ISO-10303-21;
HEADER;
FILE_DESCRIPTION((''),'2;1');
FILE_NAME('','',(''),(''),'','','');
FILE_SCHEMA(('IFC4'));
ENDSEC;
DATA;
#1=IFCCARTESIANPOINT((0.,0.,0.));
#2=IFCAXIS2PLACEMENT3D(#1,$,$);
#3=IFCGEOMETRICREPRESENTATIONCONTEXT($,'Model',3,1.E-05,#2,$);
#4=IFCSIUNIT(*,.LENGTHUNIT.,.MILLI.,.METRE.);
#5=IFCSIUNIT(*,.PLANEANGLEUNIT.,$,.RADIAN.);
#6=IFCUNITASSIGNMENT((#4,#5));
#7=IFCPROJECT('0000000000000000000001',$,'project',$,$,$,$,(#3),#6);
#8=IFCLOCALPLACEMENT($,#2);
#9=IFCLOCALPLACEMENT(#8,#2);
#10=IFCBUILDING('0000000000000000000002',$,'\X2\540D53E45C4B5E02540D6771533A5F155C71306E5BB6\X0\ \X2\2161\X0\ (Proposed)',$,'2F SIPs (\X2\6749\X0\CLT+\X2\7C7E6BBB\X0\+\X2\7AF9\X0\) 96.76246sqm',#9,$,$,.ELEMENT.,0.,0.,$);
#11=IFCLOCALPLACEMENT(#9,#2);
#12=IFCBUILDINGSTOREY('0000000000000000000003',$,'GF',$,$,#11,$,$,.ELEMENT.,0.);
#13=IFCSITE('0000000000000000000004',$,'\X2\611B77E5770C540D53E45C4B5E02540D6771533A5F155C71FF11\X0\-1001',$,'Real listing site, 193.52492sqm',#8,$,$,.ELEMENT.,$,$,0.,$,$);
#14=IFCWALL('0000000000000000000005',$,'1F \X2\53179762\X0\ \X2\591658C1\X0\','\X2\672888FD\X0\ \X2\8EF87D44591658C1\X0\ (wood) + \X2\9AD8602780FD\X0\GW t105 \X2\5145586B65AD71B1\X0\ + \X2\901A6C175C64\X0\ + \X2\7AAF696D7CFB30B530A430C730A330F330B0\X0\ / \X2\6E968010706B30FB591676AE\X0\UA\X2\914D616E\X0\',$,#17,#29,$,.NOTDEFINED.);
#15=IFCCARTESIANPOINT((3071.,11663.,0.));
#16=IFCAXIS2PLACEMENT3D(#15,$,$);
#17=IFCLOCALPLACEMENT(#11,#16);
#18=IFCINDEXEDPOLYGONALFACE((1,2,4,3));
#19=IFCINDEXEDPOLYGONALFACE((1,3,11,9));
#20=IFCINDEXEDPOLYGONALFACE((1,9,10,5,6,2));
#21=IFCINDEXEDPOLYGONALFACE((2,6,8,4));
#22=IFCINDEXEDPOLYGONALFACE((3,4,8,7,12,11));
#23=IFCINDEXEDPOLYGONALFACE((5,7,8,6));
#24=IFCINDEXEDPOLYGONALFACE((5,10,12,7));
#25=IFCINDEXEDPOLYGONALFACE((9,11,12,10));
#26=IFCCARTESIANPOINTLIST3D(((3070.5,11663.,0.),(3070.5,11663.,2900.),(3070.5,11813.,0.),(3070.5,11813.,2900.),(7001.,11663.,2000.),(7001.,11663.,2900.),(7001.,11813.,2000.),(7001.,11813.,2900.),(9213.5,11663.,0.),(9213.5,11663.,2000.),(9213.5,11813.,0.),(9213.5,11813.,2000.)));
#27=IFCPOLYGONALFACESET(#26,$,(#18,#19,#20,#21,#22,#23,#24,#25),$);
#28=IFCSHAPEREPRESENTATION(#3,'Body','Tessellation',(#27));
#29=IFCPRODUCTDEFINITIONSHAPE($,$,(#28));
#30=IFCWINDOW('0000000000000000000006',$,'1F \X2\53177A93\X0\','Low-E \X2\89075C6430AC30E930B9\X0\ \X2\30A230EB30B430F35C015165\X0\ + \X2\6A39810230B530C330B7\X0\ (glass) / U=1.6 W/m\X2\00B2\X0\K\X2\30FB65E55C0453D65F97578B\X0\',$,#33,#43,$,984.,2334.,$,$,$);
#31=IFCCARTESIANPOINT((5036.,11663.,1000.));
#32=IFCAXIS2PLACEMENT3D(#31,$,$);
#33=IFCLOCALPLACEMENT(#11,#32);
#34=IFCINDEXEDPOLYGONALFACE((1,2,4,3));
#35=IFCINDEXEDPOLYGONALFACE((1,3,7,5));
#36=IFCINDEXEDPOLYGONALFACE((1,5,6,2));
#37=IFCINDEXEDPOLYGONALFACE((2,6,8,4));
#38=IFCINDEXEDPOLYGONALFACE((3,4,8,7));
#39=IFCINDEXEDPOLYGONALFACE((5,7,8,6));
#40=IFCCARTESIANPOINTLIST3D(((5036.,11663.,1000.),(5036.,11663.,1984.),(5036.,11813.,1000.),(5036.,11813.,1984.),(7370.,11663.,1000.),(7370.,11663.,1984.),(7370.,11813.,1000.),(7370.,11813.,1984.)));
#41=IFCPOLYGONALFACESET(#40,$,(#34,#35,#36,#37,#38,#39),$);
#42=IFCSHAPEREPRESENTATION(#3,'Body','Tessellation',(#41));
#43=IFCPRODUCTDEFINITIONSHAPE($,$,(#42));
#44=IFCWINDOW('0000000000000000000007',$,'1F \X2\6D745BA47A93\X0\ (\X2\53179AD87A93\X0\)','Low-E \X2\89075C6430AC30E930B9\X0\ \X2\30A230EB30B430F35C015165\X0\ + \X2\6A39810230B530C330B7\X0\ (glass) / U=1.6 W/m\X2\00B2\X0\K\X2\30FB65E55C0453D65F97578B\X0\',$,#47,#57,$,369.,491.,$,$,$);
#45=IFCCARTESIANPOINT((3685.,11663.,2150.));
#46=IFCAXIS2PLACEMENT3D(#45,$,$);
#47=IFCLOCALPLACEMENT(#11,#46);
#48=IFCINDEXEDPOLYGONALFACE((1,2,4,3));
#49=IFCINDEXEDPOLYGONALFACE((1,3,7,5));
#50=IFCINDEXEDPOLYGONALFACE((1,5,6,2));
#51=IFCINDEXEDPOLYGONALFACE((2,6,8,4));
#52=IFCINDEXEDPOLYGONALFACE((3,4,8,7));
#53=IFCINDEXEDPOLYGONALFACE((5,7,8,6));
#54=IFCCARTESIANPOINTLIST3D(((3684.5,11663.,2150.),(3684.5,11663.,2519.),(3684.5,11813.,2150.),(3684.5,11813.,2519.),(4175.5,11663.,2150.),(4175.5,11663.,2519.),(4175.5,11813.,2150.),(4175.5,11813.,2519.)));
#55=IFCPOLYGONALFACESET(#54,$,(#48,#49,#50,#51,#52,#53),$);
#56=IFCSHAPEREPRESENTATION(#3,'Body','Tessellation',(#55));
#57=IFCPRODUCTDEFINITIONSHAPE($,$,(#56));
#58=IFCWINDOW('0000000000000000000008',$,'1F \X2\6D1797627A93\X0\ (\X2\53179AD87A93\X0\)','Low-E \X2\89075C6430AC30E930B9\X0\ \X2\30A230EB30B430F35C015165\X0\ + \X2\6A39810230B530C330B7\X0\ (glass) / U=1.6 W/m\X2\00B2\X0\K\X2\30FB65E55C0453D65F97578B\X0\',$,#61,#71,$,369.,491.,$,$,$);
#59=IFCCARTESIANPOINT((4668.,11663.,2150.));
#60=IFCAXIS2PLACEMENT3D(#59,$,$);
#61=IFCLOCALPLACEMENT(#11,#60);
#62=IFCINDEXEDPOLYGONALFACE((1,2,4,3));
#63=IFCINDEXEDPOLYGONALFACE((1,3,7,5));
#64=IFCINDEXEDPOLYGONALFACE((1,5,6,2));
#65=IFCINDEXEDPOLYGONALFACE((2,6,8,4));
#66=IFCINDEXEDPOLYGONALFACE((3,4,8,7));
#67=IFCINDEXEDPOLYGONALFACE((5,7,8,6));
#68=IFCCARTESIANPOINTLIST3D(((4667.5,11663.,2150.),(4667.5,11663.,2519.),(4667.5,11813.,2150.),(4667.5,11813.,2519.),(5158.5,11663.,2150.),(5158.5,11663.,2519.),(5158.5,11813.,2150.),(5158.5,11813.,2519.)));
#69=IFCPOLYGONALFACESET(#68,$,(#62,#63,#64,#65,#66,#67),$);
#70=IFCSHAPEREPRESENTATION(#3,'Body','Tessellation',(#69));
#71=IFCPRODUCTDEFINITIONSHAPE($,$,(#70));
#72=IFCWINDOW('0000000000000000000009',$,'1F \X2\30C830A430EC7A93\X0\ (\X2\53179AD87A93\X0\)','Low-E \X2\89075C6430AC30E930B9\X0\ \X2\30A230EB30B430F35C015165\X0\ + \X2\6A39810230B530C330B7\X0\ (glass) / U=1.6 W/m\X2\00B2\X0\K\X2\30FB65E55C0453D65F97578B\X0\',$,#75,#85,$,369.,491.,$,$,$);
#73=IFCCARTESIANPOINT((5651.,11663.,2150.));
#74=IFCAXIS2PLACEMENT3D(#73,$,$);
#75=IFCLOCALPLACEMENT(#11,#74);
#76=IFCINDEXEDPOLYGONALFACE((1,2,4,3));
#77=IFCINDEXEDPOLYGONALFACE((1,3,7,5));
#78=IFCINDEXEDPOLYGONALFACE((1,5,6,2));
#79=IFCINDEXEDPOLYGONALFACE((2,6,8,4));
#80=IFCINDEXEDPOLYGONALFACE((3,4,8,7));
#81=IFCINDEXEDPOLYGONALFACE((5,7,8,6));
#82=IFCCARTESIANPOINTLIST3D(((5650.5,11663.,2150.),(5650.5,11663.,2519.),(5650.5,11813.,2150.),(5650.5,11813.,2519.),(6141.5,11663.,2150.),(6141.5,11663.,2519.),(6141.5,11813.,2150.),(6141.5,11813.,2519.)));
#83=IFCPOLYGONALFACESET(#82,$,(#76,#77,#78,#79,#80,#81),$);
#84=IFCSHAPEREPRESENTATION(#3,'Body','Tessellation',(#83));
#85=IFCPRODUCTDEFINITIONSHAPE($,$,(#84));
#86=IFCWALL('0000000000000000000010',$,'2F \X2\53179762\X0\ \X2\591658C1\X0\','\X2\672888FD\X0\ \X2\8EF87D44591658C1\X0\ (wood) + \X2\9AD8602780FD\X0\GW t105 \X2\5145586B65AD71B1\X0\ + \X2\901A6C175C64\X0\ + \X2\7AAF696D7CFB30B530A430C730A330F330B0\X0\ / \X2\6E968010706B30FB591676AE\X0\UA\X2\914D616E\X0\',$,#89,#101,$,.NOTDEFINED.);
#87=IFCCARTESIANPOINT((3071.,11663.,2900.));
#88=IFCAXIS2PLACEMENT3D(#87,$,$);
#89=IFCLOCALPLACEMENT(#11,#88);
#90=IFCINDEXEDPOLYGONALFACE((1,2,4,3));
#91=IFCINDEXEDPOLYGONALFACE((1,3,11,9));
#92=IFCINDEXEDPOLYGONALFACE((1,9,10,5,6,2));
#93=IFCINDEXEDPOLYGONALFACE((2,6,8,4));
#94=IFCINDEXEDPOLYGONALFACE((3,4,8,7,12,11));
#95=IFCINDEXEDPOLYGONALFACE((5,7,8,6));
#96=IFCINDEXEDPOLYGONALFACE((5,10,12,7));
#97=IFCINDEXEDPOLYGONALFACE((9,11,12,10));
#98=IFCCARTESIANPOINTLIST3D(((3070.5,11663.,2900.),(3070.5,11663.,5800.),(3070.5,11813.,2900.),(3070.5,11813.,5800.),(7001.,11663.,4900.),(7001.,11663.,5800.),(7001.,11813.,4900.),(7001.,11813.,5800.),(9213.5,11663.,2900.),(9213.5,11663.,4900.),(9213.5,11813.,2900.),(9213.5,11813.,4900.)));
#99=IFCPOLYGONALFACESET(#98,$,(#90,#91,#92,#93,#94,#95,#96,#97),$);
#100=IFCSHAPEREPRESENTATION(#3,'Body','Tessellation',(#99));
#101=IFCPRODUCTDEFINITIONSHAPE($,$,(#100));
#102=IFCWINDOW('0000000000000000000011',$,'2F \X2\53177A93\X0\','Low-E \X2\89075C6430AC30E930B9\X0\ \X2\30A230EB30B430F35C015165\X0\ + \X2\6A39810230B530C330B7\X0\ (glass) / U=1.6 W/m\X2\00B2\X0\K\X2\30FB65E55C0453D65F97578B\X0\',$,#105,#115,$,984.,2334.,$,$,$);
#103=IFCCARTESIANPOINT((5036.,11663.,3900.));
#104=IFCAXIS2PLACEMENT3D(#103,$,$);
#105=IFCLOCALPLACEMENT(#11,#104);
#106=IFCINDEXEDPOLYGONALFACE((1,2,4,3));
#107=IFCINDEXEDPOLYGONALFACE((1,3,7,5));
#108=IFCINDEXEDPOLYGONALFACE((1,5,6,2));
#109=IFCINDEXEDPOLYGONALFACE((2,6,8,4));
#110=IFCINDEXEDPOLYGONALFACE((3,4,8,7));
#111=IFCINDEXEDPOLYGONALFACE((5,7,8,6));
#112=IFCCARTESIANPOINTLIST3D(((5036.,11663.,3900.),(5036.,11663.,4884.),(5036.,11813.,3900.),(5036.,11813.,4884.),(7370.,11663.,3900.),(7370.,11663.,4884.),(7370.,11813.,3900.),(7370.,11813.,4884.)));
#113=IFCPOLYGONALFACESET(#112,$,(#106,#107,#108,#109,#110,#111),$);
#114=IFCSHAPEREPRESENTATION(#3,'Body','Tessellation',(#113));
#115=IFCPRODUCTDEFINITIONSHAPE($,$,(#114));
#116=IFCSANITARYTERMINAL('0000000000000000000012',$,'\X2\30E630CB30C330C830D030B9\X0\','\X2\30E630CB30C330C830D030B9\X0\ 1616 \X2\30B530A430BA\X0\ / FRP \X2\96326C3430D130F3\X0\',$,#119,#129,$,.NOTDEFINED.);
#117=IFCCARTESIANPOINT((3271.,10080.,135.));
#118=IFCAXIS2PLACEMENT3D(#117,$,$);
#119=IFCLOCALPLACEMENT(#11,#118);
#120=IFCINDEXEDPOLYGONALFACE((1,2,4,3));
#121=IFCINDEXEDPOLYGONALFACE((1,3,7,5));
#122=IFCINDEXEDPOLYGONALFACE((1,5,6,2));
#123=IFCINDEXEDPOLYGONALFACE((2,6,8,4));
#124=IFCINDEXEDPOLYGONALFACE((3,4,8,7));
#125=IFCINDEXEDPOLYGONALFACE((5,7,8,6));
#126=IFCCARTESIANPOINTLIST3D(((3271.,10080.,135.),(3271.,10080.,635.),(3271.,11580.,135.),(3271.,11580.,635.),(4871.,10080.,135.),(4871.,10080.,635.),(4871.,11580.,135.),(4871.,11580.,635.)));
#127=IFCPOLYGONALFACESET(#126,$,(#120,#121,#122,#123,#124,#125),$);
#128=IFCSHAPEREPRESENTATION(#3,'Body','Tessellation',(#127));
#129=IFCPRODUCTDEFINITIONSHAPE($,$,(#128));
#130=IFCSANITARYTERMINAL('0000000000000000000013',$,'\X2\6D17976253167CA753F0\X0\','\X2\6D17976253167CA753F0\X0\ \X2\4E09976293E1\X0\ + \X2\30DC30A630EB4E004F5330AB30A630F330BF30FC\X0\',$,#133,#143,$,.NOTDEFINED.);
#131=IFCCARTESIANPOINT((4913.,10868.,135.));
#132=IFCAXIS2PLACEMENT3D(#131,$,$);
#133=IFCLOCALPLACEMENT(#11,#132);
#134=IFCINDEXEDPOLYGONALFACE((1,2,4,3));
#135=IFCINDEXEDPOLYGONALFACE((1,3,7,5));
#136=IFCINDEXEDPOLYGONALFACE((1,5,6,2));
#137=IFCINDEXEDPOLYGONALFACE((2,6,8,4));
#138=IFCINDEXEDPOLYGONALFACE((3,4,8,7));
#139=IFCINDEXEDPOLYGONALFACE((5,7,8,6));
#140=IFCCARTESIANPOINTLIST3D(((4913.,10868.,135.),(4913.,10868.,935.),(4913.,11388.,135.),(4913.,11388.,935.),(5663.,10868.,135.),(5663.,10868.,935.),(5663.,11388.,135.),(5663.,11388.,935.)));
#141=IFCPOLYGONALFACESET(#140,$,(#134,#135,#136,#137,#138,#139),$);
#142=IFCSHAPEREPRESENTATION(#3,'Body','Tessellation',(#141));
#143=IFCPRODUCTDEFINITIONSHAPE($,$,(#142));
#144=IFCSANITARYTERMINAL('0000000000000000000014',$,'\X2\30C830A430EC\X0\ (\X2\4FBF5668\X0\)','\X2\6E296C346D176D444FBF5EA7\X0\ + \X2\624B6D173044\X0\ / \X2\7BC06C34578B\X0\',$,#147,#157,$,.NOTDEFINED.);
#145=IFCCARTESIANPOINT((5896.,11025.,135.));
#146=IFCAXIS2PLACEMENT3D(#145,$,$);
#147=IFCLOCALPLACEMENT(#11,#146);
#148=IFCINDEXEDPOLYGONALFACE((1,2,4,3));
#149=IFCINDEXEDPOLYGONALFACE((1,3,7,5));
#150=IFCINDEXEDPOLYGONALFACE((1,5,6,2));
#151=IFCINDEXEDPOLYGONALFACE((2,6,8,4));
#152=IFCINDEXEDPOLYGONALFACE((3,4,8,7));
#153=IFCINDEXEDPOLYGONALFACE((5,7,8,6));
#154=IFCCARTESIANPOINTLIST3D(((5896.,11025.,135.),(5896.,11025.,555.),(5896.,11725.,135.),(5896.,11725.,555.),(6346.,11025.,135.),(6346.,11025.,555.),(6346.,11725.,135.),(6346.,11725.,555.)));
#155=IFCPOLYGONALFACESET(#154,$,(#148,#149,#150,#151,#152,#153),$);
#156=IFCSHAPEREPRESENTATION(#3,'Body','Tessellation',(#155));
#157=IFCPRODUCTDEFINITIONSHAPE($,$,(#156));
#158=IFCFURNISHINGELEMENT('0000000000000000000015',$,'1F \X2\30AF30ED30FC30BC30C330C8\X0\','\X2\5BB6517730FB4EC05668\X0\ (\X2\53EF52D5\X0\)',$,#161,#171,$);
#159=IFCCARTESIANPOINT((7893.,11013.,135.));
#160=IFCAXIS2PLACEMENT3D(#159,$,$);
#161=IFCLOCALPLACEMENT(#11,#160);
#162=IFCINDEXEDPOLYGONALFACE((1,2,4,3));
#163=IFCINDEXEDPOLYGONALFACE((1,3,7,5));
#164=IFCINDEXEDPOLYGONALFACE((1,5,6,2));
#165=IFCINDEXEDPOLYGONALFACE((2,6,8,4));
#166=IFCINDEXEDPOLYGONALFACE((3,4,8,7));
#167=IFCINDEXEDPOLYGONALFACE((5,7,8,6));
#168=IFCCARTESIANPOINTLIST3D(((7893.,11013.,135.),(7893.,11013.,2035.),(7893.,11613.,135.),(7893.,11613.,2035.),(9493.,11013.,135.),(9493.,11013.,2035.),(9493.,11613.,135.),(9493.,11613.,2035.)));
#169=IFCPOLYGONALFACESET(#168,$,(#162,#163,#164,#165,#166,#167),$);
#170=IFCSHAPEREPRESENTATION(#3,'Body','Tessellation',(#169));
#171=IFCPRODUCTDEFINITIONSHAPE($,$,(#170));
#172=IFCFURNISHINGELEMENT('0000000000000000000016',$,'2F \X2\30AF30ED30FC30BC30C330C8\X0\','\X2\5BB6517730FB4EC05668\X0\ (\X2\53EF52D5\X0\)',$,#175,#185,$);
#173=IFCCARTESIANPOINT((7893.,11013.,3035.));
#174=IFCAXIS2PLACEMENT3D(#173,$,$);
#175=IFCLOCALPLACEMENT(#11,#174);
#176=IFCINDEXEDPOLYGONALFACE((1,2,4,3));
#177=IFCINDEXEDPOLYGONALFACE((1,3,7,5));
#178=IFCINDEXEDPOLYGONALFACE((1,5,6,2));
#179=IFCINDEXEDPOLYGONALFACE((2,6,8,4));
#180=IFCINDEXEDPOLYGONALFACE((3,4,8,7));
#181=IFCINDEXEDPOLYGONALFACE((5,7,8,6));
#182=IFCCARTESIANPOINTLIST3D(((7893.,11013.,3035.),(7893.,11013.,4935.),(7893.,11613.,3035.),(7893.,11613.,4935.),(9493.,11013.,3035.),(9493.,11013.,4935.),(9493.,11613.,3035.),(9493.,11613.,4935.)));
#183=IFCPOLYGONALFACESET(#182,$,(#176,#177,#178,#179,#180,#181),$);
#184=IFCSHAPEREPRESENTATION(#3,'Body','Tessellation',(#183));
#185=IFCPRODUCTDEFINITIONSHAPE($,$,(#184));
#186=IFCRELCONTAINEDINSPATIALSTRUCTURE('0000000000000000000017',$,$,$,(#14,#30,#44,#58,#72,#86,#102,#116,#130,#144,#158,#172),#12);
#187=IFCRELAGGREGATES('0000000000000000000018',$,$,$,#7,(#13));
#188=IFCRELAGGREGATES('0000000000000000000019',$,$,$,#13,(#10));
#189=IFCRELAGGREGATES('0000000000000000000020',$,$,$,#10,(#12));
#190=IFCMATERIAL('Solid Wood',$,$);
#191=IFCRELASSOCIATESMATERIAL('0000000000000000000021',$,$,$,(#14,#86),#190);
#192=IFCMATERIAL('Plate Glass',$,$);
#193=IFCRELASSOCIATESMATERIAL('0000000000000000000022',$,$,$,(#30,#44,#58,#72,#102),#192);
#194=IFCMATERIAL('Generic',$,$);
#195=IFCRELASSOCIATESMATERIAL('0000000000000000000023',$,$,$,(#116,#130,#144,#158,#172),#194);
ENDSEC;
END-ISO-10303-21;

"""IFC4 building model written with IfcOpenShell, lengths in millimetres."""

from ifc_helpers import new_model, si_unit, frame, frame_2d, origin, place, context, project, spatial, rectangle, extrude, material, element, fill, save


model = new_model("IFC4")

# Units and contexts
model_context = context("Model", 3, precision=1e-05, world=origin())
ifc_project = project(units=[si_unit("LENGTHUNIT", "METRE", prefix="MILLI"), si_unit("PLANEANGLEUNIT", "RADIAN")], contexts=[model_context])

# Site, building, storey
site_placement = place(None, origin())
site = spatial("IfcSite", under=ifc_project, at=site_placement, Name="愛知県名古屋市名東区引山１-1001", ObjectType="Real listing site, 193.52492sqm", CompositionType="ELEMENT", RefElevation=0.0)
building_placement = place(site_placement, origin())
building = spatial("IfcBuilding", under=site, at=building_placement, Name="名古屋市名東区引山の家 Ⅱ (Proposed)", ObjectType="2F SIPs (杉CLT+籾殻+竹) 96.76246sqm", CompositionType="ELEMENT", ElevationOfRefHeight=0.0, ElevationOfTerrain=0.0)
storey_placement = place(building_placement, origin())
storey = spatial("IfcBuildingStorey", under=building, at=storey_placement, Name="GF", CompositionType="ELEMENT", Elevation=0.0)

# Wall, openings, windows
ifc_material_1 = material(Name="Solid Wood")
wall_1_placement = place(storey_placement, frame((3071.0, 11663.0, 0.0)))
wall_1 = element("IfcWall", 1, at=wall_1_placement, inside=storey, material=ifc_material_1, Name="1F 北面 外壁", Description="木製 軸組外壁 (wood) + 高性能GW t105 充填断熱 + 通気層 + 窯業系サイディング / 準耐火・外皮UA配慮", PredefinedType="NOTDEFINED", context=model_context, shape_type="SweptSolid", body=[
    extrude(rectangle(XDim=6143.0, YDim=150.0, at=frame_2d((3071.0, 75.0))), frame((3071.0, 11663.0, 0.0)), (0.0, 0.0, 1.0), 2900.0),
])
opening_1_placement = place(storey_placement, frame((5036.0, 11663.0, 1000.0)))
opening_1 = element("IfcOpeningElement", 2, at=opening_1_placement, cuts=wall_1, PredefinedType="NOTDEFINED", context=model_context, shape_type="SweptSolid", body=[
    extrude(rectangle(XDim=2334.0, YDim=150.0, at=frame_2d((1167.0, 75.0))), frame((5036.0, 11663.0, 1000.0)), (0.0, 0.0, 1.0), 984.0),
])
opening_2_placement = place(storey_placement, frame((3685.0, 11663.0, 2150.0)))
opening_2 = element("IfcOpeningElement", 3, at=opening_2_placement, cuts=wall_1, PredefinedType="NOTDEFINED", context=model_context, shape_type="SweptSolid", body=[
    extrude(rectangle(XDim=491.0, YDim=150.0, at=frame_2d((245.0, 75.0))), frame((3685.0, 11663.0, 2150.0)), (0.0, 0.0, 1.0), 369.0),
])
opening_3_placement = place(storey_placement, frame((4668.0, 11663.0, 2150.0)))
opening_3 = element("IfcOpeningElement", 4, at=opening_3_placement, cuts=wall_1, PredefinedType="NOTDEFINED", context=model_context, shape_type="SweptSolid", body=[
    extrude(rectangle(XDim=491.0, YDim=150.0, at=frame_2d((245.0, 75.0))), frame((4668.0, 11663.0, 2150.0)), (0.0, 0.0, 1.0), 369.0),
])
opening_4_placement = place(storey_placement, frame((5651.0, 11663.0, 2150.0)))
opening_4 = element("IfcOpeningElement", 5, at=opening_4_placement, cuts=wall_1, PredefinedType="NOTDEFINED", context=model_context, shape_type="SweptSolid", body=[
    extrude(rectangle(XDim=491.0, YDim=150.0, at=frame_2d((245.0, 75.0))), frame((5651.0, 11663.0, 2150.0)), (0.0, 0.0, 1.0), 369.0),
])
ifc_material_2 = material(Name="Plate Glass")
window_1_placement = place(storey_placement, frame((5036.0, 11663.0, 1000.0)))
window_1 = element("IfcWindow", 6, at=window_1_placement, inside=storey, material=ifc_material_2, Name="1F 北窓", Description="Low-E 複層ガラス アルゴン封入 + 樹脂サッシ (glass) / U=1.6 W/m²K・日射取得型", OverallHeight=984.0, OverallWidth=2334.0, context=model_context, shape_type="SweptSolid", body=[
    extrude(rectangle(XDim=2334.0, YDim=150.0, at=frame_2d((1167.0, 75.0))), frame((5036.0, 11663.0, 1000.0)), (0.0, 0.0, 1.0), 984.0),
])
fill(opening_1, window_1)
window_2_placement = place(storey_placement, frame((3685.0, 11663.0, 2150.0)))
window_2 = element("IfcWindow", 7, at=window_2_placement, inside=storey, material=ifc_material_2, Name="1F 浴室窓 (北高窓)", Description="Low-E 複層ガラス アルゴン封入 + 樹脂サッシ (glass) / U=1.6 W/m²K・日射取得型", OverallHeight=369.0, OverallWidth=491.0, context=model_context, shape_type="SweptSolid", body=[
    extrude(rectangle(XDim=491.0, YDim=150.0, at=frame_2d((245.0, 75.0))), frame((3685.0, 11663.0, 2150.0)), (0.0, 0.0, 1.0), 369.0),
])
fill(opening_2, window_2)
window_3_placement = place(storey_placement, frame((4668.0, 11663.0, 2150.0)))
window_3 = element("IfcWindow", 8, at=window_3_placement, inside=storey, material=ifc_material_2, Name="1F 洗面窓 (北高窓)", Description="Low-E 複層ガラス アルゴン封入 + 樹脂サッシ (glass) / U=1.6 W/m²K・日射取得型", OverallHeight=369.0, OverallWidth=491.0, context=model_context, shape_type="SweptSolid", body=[
    extrude(rectangle(XDim=491.0, YDim=150.0, at=frame_2d((245.0, 75.0))), frame((4668.0, 11663.0, 2150.0)), (0.0, 0.0, 1.0), 369.0),
])
fill(opening_3, window_3)
window_4_placement = place(storey_placement, frame((5651.0, 11663.0, 2150.0)))
window_4 = element("IfcWindow", 9, at=window_4_placement, inside=storey, material=ifc_material_2, Name="1F トイレ窓 (北高窓)", Description="Low-E 複層ガラス アルゴン封入 + 樹脂サッシ (glass) / U=1.6 W/m²K・日射取得型", OverallHeight=369.0, OverallWidth=491.0, context=model_context, shape_type="SweptSolid", body=[
    extrude(rectangle(XDim=491.0, YDim=150.0, at=frame_2d((245.0, 75.0))), frame((5651.0, 11663.0, 2150.0)), (0.0, 0.0, 1.0), 369.0),
])
fill(opening_4, window_4)

# Wall, opening, window
wall_2_placement = place(storey_placement, frame((3071.0, 11663.0, 2900.0)))
wall_2 = element("IfcWall", 10, at=wall_2_placement, inside=storey, material=ifc_material_1, Name="2F 北面 外壁", Description="木製 軸組外壁 (wood) + 高性能GW t105 充填断熱 + 通気層 + 窯業系サイディング / 準耐火・外皮UA配慮", PredefinedType="NOTDEFINED", context=model_context, shape_type="SweptSolid", body=[
    extrude(rectangle(XDim=6143.0, YDim=150.0, at=frame_2d((3071.0, 75.0))), frame((3071.0, 11663.0, 2900.0)), (0.0, 0.0, 1.0), 2900.0),
])
opening_5_placement = place(storey_placement, frame((5036.0, 11663.0, 3900.0)))
opening_5 = element("IfcOpeningElement", 11, at=opening_5_placement, cuts=wall_2, PredefinedType="NOTDEFINED", context=model_context, shape_type="SweptSolid", body=[
    extrude(rectangle(XDim=2334.0, YDim=150.0, at=frame_2d((1167.0, 75.0))), frame((5036.0, 11663.0, 3900.0)), (0.0, 0.0, 1.0), 984.0),
])
window_5_placement = place(storey_placement, frame((5036.0, 11663.0, 3900.0)))
window_5 = element("IfcWindow", 12, at=window_5_placement, inside=storey, material=ifc_material_2, Name="2F 北窓", Description="Low-E 複層ガラス アルゴン封入 + 樹脂サッシ (glass) / U=1.6 W/m²K・日射取得型", OverallHeight=984.0, OverallWidth=2334.0, context=model_context, shape_type="SweptSolid", body=[
    extrude(rectangle(XDim=2334.0, YDim=150.0, at=frame_2d((1167.0, 75.0))), frame((5036.0, 11663.0, 3900.0)), (0.0, 0.0, 1.0), 984.0),
])
fill(opening_5, window_5)

# Sanitary terminals
ifc_material_3 = material(Name="Generic")
sanitary_terminal_1_placement = place(storey_placement, frame((3271.0, 10080.0, 135.0)))
element("IfcSanitaryTerminal", 13, at=sanitary_terminal_1_placement, inside=storey, material=ifc_material_3, Name="ユニットバス", Description="ユニットバス 1616 サイズ / FRP 防水パン", PredefinedType="NOTDEFINED", context=model_context, shape_type="SweptSolid", body=[
    extrude(rectangle(XDim=1600.0, YDim=1500.0, at=frame_2d((800.0, 750.0))), frame((3271.0, 10080.0, 135.0)), (0.0, 0.0, 1.0), 500.0),
])
sanitary_terminal_2_placement = place(storey_placement, frame((4913.0, 10868.0, 135.0)))
element("IfcSanitaryTerminal", 14, at=sanitary_terminal_2_placement, inside=storey, material=ifc_material_3, Name="洗面化粧台", Description="洗面化粧台 三面鏡 + ボウル一体カウンター", PredefinedType="NOTDEFINED", context=model_context, shape_type="SweptSolid", body=[
    extrude(rectangle(XDim=750.0, YDim=520.0, at=frame_2d((375.0, 260.0))), frame((4913.0, 10868.0, 135.0)), (0.0, 0.0, 1.0), 800.0),
])
sanitary_terminal_3_placement = place(storey_placement, frame((5896.0, 11025.0, 135.0)))
element("IfcSanitaryTerminal", 15, at=sanitary_terminal_3_placement, inside=storey, material=ifc_material_3, Name="トイレ (便器)", Description="温水洗浄便座 + 手洗い / 節水型", PredefinedType="NOTDEFINED", context=model_context, shape_type="SweptSolid", body=[
    extrude(rectangle(XDim=450.0, YDim=700.0, at=frame_2d((225.0, 350.0))), frame((5896.0, 11025.0, 135.0)), (0.0, 0.0, 1.0), 420.0),
])

# Furnishing elements
furnishing_1_placement = place(storey_placement, frame((7893.0, 11013.0, 135.0)))
element("IfcFurnishingElement", 16, at=furnishing_1_placement, inside=storey, material=ifc_material_3, Name="1F クローゼット", Description="家具・什器 (可動)", context=model_context, shape_type="SweptSolid", body=[
    extrude(rectangle(XDim=1600.0, YDim=600.0, at=frame_2d((800.0, 300.0))), frame((7893.0, 11013.0, 135.0)), (0.0, 0.0, 1.0), 1900.0),
])
furnishing_2_placement = place(storey_placement, frame((7893.0, 11013.0, 3035.0)))
element("IfcFurnishingElement", 17, at=furnishing_2_placement, inside=storey, material=ifc_material_3, Name="2F クローゼット", Description="家具・什器 (可動)", context=model_context, shape_type="SweptSolid", body=[
    extrude(rectangle(XDim=1600.0, YDim=600.0, at=frame_2d((800.0, 300.0))), frame((7893.0, 11013.0, 3035.0)), (0.0, 0.0, 1.0), 1900.0),
])

save(model, "model.ifc")
